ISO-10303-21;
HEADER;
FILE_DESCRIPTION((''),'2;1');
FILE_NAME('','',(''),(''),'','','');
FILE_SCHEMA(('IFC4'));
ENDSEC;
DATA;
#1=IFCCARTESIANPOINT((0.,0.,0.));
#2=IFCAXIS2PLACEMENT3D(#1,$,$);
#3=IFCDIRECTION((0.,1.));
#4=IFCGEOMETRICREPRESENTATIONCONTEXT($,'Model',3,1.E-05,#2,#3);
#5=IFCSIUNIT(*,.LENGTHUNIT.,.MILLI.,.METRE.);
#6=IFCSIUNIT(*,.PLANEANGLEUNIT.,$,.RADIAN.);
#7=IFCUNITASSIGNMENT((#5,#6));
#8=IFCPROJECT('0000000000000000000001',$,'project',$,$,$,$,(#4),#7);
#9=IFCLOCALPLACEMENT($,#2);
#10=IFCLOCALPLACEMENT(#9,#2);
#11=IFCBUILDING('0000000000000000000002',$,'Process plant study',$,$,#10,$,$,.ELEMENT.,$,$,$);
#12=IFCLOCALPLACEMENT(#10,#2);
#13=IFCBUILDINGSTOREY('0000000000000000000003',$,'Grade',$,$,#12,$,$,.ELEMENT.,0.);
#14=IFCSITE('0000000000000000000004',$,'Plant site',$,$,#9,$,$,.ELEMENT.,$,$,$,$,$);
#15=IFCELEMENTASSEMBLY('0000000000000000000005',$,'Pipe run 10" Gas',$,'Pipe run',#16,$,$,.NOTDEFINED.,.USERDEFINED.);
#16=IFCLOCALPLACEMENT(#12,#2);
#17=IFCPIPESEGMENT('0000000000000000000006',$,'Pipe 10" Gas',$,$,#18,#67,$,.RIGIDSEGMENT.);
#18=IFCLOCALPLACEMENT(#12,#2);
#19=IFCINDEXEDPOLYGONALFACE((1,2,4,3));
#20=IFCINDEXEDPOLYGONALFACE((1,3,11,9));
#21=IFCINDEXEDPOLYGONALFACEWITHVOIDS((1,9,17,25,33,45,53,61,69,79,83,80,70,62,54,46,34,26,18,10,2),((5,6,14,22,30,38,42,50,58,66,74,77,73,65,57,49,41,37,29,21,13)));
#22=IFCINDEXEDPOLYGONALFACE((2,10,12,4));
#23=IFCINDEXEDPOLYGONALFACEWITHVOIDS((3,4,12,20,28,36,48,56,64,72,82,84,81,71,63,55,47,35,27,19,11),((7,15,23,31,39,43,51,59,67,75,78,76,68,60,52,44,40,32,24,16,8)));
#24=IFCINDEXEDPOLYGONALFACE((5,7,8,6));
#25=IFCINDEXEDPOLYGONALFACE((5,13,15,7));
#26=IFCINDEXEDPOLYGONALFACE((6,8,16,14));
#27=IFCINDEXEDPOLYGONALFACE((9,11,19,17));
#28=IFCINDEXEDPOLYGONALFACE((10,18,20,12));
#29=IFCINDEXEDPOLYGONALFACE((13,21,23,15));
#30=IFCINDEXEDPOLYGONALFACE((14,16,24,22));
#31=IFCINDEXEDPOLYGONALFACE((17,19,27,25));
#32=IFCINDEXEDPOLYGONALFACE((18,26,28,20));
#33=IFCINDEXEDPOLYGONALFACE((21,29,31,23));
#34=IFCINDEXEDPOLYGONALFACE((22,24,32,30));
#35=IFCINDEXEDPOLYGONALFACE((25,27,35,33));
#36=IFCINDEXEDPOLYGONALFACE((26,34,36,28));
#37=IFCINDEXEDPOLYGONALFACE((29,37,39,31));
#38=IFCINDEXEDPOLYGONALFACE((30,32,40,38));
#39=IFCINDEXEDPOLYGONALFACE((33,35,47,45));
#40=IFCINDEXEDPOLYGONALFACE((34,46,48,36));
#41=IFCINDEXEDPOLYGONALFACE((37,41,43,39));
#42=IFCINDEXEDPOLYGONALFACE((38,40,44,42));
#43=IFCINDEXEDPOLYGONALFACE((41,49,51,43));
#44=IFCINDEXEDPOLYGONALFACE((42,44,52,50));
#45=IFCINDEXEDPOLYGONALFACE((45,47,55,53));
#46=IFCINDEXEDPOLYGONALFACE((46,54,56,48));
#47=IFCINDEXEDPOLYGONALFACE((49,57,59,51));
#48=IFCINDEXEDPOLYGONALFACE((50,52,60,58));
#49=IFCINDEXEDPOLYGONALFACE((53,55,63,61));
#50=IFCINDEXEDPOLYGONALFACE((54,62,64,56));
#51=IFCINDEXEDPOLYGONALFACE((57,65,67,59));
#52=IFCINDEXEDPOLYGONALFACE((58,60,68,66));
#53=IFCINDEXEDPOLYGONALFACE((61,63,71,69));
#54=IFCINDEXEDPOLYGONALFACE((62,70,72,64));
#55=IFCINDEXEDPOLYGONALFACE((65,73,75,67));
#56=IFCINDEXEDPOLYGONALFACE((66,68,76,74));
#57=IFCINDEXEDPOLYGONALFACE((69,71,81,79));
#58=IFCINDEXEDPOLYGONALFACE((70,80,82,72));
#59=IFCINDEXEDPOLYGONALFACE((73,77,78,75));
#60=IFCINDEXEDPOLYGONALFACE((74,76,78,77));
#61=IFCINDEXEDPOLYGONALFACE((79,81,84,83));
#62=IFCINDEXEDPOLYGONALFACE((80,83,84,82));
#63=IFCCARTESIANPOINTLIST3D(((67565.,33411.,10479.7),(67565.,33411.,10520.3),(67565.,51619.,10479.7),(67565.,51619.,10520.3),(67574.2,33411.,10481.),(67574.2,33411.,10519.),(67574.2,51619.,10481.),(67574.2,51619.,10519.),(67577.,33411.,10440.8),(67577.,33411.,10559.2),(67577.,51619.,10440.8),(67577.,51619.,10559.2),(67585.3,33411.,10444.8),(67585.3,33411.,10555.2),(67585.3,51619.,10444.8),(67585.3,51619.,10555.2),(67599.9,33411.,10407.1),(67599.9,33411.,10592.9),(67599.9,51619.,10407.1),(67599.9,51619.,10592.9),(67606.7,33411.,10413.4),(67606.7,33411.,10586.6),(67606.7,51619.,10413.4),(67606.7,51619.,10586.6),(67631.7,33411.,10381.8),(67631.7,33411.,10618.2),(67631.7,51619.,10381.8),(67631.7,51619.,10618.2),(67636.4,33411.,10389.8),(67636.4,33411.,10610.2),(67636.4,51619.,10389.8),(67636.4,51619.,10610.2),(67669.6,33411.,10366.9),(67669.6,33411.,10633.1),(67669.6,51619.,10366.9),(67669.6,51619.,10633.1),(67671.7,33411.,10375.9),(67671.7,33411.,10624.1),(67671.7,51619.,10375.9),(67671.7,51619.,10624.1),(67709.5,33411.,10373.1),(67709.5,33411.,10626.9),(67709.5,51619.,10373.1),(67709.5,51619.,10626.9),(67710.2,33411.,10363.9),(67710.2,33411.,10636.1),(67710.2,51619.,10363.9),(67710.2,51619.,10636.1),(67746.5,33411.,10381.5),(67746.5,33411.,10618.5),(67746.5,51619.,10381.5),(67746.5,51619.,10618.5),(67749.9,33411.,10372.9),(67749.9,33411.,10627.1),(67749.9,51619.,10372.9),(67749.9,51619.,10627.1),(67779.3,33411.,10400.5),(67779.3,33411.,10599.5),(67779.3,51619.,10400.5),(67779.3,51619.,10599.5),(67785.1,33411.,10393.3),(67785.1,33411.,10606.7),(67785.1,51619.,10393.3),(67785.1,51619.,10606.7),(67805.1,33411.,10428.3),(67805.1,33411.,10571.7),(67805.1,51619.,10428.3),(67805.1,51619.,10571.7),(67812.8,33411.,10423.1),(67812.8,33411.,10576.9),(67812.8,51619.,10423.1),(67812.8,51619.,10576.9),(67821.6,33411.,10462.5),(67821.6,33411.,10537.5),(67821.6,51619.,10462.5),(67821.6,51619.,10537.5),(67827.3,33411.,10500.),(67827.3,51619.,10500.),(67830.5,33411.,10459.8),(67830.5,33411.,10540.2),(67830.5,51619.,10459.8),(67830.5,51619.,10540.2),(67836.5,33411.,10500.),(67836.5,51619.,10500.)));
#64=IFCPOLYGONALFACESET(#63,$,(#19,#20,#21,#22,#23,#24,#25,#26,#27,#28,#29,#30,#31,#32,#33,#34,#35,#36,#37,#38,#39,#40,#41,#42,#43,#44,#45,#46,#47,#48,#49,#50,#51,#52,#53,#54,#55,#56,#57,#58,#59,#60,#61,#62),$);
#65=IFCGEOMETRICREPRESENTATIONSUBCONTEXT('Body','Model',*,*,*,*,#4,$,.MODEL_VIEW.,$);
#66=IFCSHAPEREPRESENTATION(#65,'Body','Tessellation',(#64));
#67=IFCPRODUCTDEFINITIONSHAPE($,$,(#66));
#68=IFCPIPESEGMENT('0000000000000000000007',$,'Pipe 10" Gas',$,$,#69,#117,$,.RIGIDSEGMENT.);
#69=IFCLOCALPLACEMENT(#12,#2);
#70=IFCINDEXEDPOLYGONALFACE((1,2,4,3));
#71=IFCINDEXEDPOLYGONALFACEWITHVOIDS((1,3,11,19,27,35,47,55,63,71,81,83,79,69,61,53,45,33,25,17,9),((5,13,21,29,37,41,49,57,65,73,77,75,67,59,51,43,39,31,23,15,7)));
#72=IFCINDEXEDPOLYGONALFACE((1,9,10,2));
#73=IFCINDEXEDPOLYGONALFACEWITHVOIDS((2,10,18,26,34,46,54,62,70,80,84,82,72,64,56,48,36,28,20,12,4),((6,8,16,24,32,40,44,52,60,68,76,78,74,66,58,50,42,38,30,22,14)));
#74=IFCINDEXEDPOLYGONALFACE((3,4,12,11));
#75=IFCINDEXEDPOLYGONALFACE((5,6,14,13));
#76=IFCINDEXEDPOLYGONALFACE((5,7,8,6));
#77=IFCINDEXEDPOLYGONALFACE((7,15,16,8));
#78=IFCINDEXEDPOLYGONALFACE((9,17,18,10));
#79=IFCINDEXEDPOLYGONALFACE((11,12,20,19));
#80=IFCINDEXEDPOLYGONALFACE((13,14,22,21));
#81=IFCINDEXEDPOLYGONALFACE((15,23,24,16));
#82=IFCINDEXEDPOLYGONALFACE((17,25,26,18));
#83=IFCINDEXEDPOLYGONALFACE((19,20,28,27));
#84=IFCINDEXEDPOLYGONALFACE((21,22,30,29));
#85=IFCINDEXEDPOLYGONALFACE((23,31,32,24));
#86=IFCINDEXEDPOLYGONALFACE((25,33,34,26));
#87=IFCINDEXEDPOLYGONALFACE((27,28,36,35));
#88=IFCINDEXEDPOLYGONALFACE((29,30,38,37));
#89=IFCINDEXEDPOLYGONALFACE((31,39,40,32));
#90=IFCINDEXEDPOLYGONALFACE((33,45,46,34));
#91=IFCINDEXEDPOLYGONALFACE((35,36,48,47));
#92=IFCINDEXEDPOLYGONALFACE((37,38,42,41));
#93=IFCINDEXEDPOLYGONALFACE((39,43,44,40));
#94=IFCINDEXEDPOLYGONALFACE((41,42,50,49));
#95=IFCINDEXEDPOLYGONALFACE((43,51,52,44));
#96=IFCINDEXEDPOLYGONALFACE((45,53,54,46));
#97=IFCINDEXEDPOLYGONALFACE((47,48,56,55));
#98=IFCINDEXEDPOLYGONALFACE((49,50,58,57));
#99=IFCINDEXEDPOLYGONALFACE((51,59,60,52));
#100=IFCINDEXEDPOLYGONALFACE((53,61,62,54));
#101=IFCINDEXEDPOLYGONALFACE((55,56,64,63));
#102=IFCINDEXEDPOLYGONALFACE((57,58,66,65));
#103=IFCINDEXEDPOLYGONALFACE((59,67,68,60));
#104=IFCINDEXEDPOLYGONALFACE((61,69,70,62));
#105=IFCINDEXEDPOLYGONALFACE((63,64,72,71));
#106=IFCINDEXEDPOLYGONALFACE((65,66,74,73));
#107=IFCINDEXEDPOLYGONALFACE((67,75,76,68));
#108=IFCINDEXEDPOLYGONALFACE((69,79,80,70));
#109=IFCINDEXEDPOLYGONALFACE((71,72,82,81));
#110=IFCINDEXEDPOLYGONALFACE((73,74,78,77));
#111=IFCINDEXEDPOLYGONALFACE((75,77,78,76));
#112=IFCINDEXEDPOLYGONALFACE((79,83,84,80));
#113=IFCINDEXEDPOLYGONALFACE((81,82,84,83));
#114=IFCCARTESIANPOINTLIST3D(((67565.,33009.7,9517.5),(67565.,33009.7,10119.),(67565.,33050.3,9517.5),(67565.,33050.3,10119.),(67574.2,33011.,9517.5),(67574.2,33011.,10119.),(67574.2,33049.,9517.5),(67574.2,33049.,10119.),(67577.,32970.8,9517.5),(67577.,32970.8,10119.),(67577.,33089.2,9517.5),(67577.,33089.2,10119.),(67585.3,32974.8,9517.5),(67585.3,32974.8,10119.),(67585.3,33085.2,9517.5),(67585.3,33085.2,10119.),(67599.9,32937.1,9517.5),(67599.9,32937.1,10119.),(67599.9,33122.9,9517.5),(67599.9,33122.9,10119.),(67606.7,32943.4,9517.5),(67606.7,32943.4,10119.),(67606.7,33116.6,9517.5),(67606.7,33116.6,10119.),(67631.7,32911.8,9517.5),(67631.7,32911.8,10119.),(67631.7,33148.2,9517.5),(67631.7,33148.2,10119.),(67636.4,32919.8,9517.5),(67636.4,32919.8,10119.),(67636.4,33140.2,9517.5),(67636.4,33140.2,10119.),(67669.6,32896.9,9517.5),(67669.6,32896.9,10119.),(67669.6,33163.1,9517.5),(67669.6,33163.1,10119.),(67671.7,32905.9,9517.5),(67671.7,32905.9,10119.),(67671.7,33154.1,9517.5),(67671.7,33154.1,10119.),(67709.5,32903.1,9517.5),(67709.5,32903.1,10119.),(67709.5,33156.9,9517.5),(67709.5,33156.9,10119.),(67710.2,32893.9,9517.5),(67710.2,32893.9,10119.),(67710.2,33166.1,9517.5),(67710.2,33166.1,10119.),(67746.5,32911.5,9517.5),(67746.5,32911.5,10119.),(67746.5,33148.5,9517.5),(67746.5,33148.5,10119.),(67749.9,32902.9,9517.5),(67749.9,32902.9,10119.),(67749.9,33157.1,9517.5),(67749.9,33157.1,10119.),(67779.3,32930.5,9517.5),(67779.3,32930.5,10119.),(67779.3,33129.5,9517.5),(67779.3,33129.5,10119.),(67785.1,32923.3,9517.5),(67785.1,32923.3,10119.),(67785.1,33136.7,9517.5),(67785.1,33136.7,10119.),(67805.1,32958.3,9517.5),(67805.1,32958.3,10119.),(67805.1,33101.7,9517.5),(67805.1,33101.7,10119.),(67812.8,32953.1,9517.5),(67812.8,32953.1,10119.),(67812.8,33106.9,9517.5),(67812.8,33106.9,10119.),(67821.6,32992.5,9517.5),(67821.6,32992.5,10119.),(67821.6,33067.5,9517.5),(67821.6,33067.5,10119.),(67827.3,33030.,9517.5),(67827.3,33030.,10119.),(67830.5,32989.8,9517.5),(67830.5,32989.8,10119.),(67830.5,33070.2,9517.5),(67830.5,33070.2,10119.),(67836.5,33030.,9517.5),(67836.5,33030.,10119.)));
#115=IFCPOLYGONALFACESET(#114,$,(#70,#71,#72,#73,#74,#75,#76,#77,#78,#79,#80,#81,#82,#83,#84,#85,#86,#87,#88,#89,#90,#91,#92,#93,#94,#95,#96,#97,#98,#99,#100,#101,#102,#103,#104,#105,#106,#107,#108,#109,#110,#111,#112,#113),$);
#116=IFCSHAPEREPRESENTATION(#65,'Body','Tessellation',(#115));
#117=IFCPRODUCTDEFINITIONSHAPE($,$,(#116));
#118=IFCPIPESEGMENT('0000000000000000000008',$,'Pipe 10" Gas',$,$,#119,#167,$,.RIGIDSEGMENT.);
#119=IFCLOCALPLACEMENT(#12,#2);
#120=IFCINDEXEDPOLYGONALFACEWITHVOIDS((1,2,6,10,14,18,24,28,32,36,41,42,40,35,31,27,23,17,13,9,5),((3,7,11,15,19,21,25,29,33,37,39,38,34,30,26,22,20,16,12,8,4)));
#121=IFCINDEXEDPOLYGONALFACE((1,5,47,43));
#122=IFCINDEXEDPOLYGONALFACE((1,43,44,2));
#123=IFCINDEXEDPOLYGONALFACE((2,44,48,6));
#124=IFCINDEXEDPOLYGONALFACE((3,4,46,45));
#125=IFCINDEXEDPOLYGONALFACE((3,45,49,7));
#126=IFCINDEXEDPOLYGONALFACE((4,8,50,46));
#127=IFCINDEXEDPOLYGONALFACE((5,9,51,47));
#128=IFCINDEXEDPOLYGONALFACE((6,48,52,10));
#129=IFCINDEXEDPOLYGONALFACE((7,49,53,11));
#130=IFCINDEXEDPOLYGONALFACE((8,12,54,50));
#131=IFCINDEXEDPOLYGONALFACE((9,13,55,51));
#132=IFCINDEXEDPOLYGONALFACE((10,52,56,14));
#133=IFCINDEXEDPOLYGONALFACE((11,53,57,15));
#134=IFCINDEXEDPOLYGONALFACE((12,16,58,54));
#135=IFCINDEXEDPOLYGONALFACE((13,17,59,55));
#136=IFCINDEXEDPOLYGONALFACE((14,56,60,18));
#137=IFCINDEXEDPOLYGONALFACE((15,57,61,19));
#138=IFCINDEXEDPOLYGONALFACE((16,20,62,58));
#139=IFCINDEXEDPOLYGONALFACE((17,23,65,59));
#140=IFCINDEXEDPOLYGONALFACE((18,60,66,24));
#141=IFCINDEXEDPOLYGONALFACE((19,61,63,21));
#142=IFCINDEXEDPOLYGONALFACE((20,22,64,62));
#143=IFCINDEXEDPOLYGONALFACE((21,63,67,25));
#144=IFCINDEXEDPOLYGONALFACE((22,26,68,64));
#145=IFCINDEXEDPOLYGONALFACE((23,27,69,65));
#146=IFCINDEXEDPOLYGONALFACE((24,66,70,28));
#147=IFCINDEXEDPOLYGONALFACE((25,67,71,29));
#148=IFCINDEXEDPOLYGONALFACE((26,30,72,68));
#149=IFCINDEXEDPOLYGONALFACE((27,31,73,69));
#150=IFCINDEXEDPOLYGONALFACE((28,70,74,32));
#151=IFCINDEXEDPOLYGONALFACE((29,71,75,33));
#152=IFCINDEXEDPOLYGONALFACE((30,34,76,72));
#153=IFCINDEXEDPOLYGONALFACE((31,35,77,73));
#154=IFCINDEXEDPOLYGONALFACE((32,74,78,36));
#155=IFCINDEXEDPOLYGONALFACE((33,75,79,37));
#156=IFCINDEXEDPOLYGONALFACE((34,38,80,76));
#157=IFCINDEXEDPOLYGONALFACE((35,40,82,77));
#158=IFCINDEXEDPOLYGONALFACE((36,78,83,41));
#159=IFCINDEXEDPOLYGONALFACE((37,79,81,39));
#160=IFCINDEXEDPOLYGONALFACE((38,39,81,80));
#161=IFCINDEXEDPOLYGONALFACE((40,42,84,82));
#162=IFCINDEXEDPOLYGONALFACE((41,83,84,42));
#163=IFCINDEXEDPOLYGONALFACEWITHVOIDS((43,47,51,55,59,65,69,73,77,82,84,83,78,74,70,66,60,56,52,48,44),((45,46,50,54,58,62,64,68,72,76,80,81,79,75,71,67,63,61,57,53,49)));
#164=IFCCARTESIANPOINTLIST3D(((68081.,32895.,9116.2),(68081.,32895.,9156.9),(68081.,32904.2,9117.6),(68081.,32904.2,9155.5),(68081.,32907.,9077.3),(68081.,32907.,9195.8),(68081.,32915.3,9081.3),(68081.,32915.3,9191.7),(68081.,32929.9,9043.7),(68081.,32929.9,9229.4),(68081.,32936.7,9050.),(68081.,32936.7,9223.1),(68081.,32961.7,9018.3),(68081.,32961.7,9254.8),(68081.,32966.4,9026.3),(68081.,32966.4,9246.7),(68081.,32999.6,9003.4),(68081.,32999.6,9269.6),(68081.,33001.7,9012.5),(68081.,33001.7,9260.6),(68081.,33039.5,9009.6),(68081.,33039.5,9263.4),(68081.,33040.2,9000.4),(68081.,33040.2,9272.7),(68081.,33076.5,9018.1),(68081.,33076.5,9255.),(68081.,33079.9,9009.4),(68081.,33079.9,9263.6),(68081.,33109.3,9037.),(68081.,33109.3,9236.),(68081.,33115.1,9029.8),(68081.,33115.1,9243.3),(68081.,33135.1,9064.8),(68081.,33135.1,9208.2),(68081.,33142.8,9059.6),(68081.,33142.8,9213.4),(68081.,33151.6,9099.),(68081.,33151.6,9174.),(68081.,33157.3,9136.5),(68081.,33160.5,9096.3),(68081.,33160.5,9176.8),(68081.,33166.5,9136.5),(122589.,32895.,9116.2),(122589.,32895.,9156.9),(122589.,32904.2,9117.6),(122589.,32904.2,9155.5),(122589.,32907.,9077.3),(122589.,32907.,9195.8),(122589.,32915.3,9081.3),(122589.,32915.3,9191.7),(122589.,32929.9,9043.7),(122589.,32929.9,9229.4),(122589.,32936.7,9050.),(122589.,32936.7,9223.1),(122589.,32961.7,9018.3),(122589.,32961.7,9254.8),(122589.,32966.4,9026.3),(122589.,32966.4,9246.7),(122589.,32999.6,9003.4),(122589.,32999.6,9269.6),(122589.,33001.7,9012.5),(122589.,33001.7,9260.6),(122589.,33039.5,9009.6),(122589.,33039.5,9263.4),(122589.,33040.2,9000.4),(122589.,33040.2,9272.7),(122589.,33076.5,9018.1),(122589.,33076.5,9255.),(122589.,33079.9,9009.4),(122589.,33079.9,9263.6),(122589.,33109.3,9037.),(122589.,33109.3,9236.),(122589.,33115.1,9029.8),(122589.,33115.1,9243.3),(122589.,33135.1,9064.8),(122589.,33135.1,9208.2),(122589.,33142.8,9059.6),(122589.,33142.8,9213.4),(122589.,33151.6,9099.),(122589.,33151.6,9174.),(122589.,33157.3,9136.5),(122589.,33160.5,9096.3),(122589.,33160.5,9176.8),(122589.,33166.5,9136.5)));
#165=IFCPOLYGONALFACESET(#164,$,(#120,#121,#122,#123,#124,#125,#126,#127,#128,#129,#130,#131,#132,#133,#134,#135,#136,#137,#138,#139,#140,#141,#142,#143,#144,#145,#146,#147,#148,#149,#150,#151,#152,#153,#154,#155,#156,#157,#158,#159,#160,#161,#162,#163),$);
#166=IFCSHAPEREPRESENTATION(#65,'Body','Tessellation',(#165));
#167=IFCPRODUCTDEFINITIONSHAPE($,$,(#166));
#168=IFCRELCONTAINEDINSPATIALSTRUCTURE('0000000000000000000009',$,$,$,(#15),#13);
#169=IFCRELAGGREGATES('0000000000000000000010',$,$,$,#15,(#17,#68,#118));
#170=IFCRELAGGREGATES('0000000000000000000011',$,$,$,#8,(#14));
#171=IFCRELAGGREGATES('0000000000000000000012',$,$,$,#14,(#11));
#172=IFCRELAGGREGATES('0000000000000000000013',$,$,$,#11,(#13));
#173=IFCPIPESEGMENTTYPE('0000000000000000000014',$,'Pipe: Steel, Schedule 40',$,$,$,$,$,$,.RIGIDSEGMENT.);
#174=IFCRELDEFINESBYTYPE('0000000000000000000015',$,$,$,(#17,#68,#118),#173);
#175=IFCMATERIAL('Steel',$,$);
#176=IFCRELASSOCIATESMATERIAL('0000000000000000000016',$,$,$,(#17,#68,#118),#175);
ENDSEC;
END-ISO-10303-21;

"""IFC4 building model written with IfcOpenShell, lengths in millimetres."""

from ifc_helpers import new_model, si_unit, direction, frame, origin, origin_with_axes, origin_2d, place, context, subcontext, project, spatial, hollow_circle, extrude, material, type_object, element, aggregate, save


model = new_model("IFC4")

# Units and contexts
model_context = context("Model", 3, precision=1e-05, world=origin(), true_north=direction((0.0, 1.0)))
body_context = subcontext(model_context, "Body", "Model", "MODEL_VIEW")
ifc_project = project(units=[si_unit("LENGTHUNIT", "METRE", prefix="MILLI"), si_unit("PLANEANGLEUNIT", "RADIAN")], contexts=[model_context])

# Site, building, storey
site_placement = place(None, origin())
site = spatial("IfcSite", under=ifc_project, at=site_placement, Name="Plant site", CompositionType="ELEMENT")
building_placement = place(site_placement, origin())
building = spatial("IfcBuilding", under=site, at=building_placement, Name="Process plant study", CompositionType="ELEMENT")
storey_placement = place(building_placement, origin())
storey = spatial("IfcBuildingStorey", under=building, at=storey_placement, Name="Grade", CompositionType="ELEMENT", Elevation=0.0)

# Shared definitions
ifc_material = material(Name="Steel")
pipe_segment_type = type_object("IfcPipeSegmentType", Name="Pipe: Steel, Schedule 40", PredefinedType="RIGIDSEGMENT")

# Element assembly, pipe segments
assembly_1_placement = place(storey_placement, origin_with_axes())
assembly_1 = element("IfcElementAssembly", 1, at=assembly_1_placement, inside=storey, Name="Pipe run 10\" Gas", ObjectType="Pipe run", AssemblyPlace="NOTDEFINED", PredefinedType="USERDEFINED")
pipe_segment_1_placement = place(storey_placement, origin_with_axes())
pipe_segment_1 = element("IfcPipeSegment", 2, at=pipe_segment_1_placement, type_object=pipe_segment_type, material=ifc_material, Name="Pipe 10\" Gas", PredefinedType="RIGIDSEGMENT", context=body_context, shape_type="SweptSolid", body=[
    extrude(hollow_circle(Radius=136.5, WallThickness=9.3, at=origin_2d()), frame((67700.0, 51619.0, 10500.0), z_axis=(0.0, -1.0, 0.0), x_axis=(1.0, 0.0, 0.0)), (0.0, 0.0, 1.0), 18208.0),
])
pipe_segment_2_placement = place(storey_placement, origin_with_axes())
pipe_segment_2 = element("IfcPipeSegment", 3, at=pipe_segment_2_placement, type_object=pipe_segment_type, material=ifc_material, Name="Pipe 10\" Gas", PredefinedType="RIGIDSEGMENT", context=body_context, shape_type="SweptSolid", body=[
    extrude(hollow_circle(Radius=136.5, WallThickness=9.3, at=origin_2d()), frame((67700.0, 33030.0, 10119.0), z_axis=(0.0, 0.0, -1.0), x_axis=(1.0, 0.0, 0.0)), (0.0, 0.0, 1.0), 601.5),
])
pipe_segment_3_placement = place(storey_placement, origin_with_axes())
pipe_segment_3 = element("IfcPipeSegment", 4, at=pipe_segment_3_placement, type_object=pipe_segment_type, material=ifc_material, Name="Pipe 10\" Gas", PredefinedType="RIGIDSEGMENT", context=body_context, shape_type="SweptSolid", body=[
    extrude(hollow_circle(Radius=136.5, WallThickness=9.3, at=origin_2d()), frame((68081.0, 33030.0, 9136.5), z_axis=(1.0, 0.0, 0.0), x_axis=(0.0, 1.0, 0.0)), (0.0, 0.0, 1.0), 54508.0),
])

aggregate(assembly_1, [pipe_segment_1, pipe_segment_2, pipe_segment_3])

save(model, "model.ifc")
